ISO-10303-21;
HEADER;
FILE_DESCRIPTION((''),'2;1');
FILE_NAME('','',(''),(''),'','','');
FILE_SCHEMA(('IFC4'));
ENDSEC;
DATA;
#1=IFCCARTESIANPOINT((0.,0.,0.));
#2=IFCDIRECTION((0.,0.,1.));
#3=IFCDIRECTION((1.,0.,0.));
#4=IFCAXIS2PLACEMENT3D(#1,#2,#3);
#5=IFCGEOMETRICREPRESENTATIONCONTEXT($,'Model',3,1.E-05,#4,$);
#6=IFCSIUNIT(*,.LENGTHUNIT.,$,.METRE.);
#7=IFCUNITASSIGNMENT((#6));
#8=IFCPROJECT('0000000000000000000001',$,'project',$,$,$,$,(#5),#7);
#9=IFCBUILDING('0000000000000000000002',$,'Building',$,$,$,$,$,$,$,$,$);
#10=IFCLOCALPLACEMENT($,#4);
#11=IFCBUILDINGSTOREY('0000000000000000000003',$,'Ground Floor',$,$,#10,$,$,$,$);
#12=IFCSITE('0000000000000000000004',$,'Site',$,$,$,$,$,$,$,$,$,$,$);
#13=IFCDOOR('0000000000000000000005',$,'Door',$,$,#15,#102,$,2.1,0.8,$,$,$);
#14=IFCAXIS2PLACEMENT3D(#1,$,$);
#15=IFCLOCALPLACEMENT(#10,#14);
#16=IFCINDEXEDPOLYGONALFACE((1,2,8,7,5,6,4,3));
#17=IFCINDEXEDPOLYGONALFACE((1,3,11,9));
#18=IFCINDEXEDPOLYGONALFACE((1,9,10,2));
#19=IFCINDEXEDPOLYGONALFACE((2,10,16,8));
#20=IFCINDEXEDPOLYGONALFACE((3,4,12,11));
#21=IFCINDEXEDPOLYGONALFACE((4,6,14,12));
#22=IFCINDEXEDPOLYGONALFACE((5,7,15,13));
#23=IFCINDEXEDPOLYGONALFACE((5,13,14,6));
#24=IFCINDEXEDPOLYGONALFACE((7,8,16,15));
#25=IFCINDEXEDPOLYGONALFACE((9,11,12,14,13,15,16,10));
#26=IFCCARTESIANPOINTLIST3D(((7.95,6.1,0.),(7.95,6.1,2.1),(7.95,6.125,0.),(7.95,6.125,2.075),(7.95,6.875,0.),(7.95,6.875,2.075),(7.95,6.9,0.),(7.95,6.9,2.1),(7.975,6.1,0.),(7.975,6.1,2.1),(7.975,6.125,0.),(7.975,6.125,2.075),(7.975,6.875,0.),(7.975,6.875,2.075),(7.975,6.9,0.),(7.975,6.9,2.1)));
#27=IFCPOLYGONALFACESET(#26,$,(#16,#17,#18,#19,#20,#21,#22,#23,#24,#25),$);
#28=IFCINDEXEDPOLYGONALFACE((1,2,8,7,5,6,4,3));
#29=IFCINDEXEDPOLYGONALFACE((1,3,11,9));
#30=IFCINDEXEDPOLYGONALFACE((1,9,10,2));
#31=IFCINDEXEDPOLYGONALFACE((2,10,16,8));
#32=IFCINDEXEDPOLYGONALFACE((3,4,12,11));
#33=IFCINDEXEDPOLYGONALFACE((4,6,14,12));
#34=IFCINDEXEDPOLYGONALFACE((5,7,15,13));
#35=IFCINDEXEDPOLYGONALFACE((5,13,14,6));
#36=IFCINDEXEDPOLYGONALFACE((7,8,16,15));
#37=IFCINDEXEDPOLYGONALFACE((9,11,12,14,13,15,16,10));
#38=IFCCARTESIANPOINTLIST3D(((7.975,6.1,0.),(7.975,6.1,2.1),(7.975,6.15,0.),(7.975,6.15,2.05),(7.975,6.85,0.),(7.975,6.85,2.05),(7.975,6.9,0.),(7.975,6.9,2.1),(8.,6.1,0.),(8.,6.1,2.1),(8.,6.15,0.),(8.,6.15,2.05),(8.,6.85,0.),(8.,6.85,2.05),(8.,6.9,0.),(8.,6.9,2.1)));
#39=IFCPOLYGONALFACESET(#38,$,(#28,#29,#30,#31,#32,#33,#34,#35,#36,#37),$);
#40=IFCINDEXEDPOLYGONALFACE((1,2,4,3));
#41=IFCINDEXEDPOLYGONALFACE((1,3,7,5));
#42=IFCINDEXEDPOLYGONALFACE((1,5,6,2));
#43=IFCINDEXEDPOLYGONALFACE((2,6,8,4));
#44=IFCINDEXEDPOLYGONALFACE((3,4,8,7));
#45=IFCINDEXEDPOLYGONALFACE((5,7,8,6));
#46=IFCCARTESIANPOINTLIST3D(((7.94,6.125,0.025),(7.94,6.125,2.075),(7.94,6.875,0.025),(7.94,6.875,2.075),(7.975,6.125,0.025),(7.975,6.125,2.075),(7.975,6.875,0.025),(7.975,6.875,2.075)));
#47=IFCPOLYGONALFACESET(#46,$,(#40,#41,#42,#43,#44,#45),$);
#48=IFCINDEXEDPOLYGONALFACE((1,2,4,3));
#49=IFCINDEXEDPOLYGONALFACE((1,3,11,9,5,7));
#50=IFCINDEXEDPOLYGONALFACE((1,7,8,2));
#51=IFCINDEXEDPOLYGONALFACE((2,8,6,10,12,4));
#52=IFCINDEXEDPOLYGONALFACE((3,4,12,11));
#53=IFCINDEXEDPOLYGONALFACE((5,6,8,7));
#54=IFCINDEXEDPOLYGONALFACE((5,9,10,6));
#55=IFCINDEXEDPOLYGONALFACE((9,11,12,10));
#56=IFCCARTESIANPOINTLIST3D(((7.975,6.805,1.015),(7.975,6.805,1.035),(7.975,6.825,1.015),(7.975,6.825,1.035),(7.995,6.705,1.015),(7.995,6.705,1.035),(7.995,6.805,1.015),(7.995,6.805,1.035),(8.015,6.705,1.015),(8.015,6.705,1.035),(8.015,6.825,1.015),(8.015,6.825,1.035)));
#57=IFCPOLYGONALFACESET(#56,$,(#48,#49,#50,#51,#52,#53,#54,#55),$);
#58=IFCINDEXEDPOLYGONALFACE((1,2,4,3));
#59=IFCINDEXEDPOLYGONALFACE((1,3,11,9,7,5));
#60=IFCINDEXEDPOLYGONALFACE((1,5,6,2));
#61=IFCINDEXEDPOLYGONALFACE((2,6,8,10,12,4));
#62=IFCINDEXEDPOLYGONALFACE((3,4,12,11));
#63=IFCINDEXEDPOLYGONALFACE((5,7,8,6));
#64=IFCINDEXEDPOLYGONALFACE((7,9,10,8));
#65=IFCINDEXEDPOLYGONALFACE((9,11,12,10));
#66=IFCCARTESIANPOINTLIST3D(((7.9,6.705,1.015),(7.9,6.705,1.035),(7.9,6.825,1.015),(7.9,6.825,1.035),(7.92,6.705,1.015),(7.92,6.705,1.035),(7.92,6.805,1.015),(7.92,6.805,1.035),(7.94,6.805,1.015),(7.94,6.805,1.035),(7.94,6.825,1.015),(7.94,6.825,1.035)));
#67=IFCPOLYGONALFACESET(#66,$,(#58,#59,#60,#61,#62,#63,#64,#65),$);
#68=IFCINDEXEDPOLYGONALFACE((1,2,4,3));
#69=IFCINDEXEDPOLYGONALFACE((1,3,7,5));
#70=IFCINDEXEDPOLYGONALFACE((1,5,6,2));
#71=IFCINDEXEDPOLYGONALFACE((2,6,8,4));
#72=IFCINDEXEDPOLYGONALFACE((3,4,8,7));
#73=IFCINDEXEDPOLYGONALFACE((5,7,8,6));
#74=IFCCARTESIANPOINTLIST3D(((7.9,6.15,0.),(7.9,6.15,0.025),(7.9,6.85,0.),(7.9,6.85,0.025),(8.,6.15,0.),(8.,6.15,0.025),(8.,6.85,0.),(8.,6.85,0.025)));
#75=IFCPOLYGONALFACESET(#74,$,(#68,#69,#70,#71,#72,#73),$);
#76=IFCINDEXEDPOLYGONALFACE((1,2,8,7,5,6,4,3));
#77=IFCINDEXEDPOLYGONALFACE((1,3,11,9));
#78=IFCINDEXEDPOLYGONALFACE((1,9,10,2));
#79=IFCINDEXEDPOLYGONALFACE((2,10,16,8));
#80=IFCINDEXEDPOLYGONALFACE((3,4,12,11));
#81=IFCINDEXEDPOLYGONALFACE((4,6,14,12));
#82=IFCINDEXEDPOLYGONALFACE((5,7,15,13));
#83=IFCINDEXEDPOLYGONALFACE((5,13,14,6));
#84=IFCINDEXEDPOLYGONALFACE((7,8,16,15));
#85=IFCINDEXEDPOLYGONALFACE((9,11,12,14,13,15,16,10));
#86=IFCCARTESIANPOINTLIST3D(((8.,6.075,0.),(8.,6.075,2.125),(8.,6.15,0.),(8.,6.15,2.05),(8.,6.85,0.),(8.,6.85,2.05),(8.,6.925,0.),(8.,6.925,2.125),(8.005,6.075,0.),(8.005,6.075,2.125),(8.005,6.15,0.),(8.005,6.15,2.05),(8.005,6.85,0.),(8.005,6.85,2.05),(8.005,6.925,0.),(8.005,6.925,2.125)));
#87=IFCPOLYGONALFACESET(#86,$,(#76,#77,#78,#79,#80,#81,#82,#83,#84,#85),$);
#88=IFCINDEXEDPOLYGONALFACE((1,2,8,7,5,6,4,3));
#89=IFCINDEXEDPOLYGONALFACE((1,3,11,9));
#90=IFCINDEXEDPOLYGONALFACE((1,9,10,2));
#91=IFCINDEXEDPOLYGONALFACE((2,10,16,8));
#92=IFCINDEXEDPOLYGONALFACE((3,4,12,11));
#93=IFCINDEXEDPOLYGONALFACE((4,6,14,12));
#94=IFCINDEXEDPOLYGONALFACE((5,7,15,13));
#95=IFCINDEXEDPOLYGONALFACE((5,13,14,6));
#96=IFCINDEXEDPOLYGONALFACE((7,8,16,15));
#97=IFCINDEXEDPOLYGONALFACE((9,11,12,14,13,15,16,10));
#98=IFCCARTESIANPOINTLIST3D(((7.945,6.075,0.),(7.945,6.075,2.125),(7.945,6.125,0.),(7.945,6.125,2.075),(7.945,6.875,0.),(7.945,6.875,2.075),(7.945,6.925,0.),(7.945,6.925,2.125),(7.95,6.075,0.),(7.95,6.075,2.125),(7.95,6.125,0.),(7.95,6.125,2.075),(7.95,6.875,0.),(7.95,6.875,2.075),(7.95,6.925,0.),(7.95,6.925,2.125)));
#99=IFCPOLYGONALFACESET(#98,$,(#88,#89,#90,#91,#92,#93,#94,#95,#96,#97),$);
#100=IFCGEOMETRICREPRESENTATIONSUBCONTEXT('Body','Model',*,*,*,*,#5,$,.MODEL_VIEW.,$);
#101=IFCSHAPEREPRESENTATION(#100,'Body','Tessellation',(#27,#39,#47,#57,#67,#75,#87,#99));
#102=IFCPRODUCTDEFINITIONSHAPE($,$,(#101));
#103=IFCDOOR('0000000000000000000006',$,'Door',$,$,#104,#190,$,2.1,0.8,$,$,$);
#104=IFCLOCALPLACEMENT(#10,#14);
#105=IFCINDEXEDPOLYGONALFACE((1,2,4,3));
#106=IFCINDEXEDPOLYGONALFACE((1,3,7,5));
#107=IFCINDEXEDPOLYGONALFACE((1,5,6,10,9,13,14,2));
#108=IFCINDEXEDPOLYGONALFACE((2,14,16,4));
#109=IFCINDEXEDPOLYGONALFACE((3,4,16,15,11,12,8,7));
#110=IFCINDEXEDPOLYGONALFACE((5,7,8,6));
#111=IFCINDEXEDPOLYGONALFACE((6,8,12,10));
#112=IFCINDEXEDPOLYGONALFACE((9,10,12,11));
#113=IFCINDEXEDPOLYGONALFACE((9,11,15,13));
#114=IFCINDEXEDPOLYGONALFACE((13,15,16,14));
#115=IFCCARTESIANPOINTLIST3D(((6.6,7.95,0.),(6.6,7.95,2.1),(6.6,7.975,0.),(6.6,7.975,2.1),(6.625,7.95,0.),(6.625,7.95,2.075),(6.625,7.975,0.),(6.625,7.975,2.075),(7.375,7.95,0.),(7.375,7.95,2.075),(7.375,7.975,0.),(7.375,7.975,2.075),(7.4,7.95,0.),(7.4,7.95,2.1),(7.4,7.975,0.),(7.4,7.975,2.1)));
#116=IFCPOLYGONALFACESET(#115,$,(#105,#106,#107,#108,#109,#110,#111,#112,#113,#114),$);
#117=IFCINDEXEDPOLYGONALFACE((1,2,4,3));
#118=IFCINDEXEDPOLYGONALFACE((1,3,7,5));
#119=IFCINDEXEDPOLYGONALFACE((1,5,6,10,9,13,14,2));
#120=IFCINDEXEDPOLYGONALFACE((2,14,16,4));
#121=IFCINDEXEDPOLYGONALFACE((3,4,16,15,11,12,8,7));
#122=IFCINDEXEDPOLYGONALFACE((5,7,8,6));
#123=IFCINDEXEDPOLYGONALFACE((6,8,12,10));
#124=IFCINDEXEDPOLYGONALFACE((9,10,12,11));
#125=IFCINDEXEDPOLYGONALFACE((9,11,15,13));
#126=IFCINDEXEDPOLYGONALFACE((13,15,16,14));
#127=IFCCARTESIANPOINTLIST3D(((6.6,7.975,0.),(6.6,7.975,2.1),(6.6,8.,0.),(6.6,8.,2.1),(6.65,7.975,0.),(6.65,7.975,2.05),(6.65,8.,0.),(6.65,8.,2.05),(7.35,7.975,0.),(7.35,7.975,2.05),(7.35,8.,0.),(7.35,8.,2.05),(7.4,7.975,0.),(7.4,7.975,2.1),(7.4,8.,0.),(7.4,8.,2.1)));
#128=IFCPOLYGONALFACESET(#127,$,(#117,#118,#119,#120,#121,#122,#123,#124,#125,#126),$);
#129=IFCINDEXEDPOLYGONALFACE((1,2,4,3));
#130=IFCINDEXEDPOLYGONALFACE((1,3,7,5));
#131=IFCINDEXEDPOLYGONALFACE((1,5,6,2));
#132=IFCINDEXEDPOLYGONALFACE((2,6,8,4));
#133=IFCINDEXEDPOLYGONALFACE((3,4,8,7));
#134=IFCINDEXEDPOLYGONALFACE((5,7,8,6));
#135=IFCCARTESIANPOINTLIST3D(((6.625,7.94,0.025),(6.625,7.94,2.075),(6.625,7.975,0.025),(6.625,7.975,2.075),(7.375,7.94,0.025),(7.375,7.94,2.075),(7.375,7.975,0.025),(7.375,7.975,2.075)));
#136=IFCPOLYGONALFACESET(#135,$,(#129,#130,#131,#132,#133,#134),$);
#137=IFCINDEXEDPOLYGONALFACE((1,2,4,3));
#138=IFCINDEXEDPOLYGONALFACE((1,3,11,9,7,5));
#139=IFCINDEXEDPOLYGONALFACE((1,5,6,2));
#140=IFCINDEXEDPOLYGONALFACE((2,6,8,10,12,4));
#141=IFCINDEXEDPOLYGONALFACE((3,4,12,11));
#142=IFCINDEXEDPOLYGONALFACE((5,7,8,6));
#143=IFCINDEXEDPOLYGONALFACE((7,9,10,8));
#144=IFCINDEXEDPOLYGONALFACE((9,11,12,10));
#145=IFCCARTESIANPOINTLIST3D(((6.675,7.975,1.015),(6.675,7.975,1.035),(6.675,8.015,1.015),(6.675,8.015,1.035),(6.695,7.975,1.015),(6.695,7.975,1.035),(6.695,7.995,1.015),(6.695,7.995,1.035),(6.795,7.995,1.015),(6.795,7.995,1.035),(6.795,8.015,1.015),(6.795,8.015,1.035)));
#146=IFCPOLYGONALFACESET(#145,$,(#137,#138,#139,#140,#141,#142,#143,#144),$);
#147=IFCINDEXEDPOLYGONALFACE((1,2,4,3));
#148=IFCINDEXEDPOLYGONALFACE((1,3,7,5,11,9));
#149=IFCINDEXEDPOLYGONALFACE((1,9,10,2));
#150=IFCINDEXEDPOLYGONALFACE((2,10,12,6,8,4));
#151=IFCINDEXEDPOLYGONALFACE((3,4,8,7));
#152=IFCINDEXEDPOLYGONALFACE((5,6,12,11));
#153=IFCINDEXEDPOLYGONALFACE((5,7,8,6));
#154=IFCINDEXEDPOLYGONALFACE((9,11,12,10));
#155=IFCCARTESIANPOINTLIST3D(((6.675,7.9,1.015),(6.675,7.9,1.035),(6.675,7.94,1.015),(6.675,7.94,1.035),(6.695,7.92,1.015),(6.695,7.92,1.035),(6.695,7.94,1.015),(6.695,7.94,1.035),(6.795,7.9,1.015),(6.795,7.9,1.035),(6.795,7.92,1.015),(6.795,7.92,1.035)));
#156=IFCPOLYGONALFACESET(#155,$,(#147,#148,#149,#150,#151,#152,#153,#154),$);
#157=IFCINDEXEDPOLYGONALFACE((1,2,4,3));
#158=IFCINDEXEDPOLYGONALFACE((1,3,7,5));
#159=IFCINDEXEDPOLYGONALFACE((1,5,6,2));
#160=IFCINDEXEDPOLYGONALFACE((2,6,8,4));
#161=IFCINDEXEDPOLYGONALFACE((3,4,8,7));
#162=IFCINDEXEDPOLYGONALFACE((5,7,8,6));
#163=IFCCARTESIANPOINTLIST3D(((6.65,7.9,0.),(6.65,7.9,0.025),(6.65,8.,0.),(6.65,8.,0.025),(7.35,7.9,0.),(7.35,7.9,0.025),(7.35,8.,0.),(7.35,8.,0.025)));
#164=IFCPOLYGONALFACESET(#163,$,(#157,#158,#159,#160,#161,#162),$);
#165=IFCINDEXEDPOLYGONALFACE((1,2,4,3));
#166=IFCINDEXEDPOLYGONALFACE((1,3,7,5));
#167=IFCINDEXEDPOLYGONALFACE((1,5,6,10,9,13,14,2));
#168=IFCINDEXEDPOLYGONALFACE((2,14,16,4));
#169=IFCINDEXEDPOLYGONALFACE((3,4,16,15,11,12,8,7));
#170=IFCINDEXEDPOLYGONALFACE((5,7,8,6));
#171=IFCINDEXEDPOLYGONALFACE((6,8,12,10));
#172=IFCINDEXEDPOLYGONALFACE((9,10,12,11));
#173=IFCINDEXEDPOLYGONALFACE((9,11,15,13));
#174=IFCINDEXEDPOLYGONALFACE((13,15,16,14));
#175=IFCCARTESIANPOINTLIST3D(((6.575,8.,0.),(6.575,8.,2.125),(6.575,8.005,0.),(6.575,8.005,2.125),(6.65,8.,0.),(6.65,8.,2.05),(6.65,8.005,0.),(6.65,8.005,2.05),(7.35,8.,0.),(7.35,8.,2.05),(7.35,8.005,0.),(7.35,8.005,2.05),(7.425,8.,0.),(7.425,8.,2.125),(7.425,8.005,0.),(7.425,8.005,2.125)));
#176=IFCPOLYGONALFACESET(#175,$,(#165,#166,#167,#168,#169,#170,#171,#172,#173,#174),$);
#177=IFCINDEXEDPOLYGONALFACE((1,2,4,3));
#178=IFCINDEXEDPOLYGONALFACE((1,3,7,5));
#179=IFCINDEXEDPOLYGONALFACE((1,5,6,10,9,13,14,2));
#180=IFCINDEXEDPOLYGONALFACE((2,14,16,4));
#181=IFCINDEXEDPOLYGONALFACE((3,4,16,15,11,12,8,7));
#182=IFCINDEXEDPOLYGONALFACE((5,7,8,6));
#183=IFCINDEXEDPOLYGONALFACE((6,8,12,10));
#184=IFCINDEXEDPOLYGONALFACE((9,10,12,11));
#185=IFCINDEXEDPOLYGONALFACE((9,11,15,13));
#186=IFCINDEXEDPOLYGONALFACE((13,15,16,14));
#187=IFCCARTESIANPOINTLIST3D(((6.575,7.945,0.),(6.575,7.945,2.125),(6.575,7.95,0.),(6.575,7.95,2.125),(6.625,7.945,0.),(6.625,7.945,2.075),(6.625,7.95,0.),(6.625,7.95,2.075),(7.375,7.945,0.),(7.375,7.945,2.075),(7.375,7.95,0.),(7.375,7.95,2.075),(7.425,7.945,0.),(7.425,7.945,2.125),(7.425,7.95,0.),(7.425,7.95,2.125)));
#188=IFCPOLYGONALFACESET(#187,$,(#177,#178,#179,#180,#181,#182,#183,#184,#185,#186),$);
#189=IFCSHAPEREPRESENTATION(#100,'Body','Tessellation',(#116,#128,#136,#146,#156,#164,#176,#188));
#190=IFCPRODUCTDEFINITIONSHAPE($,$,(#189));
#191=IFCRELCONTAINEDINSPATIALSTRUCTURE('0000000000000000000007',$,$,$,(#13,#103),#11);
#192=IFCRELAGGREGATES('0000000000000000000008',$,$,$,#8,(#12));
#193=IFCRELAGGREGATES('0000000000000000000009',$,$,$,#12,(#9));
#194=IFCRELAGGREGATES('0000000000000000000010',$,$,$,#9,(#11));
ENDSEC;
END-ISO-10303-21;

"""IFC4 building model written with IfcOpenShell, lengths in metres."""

from ifc_helpers import new_model, si_unit, frame, origin_with_axes, place, context, subcontext, project, spatial, line, indexed_curve, outline, extrude, element, save


model = new_model("IFC4")

# Units and contexts
model_context = context("Model", 3, precision=1e-05, world=origin_with_axes())
body_context = subcontext(model_context, "Body", "Model", "MODEL_VIEW")
ifc_project = project(units=[si_unit("LENGTHUNIT", "METRE")], contexts=[model_context])

# Site, building, storey
site = spatial("IfcSite", under=ifc_project, Name="Site")
building = spatial("IfcBuilding", under=site, Name="Building")
storey_placement = place(None, origin_with_axes())
storey = spatial("IfcBuildingStorey", under=building, at=storey_placement, Name="Ground Floor")

# Doors
door_1_placement = place(storey_placement, frame((8.0, 6.1, 0.0), z_axis=(0.0, 0.0, 1.0), x_axis=(0.0, 1.0, 0.0)))
element("IfcDoor", 1, at=door_1_placement, inside=storey, Name="Door", OverallHeight=2.1, OverallWidth=0.8, context=body_context, shape_type="SweptSolid", body=[
    extrude(outline(indexed_curve([(0.0, 0.0), (0.0, 2.1), (0.8, 2.1), (0.8, 0.0), (0.775, 0.0), (0.775, 2.075), (0.025, 2.075), (0.025, 0.0)], segments=[line(1, 2, 3, 4, 5, 6, 7, 8, 1)])), frame((0.0, 0.025, 0.0), z_axis=(0.0, -1.0, 0.0), x_axis=(1.0, 0.0, 0.0)), (0.0, 0.0, -1.0), 0.025),
    extrude(outline(indexed_curve([(0.0, 0.0), (0.0, 2.1), (0.8, 2.1), (0.8, 0.0), (0.75, 0.0), (0.75, 2.05), (0.05, 2.05), (0.05, 0.0)], segments=[line(1, 2, 3, 4, 5, 6, 7, 8, 1)])), frame((0.0, 0.0, 0.0), z_axis=(0.0, -1.0, 0.0), x_axis=(1.0, 0.0, 0.0)), (0.0, 0.0, -1.0), 0.025),
    extrude(outline(indexed_curve([(0.0, 0.0), (0.75, 0.0), (0.75, 0.035), (0.0, 0.035)], segments=[line(1, 2, 3, 4, 1)])), frame((0.025, 0.025, 0.025), z_axis=(0.0, 0.0, 1.0), x_axis=(1.0, 0.0, 0.0)), (0.0, 0.0, 1.0), 2.05),
    extrude(outline(indexed_curve([(0.0, 0.0), (0.0, -0.04), (-0.12, -0.04), (-0.12, -0.02), (-0.02, -0.02), (-0.02, 0.0)], segments=[line(1, 2, 3, 4, 5, 6, 1)])), frame((0.725, 0.025, 1.015), z_axis=(0.0, 0.0, 1.0), x_axis=(1.0, 0.0, 0.0)), (0.0, 0.0, 1.0), 0.02),
    extrude(outline(indexed_curve([(0.0, 0.0), (0.0, 0.04), (-0.12, 0.04), (-0.12, 0.02), (-0.02, 0.02), (-0.02, 0.0)], segments=[line(1, 2, 3, 4, 5, 6, 1)])), frame((0.725, 0.06, 1.015), z_axis=(0.0, 0.0, 1.0), x_axis=(1.0, 0.0, 0.0)), (0.0, 0.0, 1.0), 0.02),
    extrude(outline(indexed_curve([(0.0, 0.0), (0.7, 0.0), (0.7, 0.1), (0.0, 0.1)], segments=[line(1, 2, 3, 4, 1)])), frame((0.05, 0.0, 0.0), z_axis=(0.0, 0.0, 1.0), x_axis=(1.0, 0.0, 0.0)), (0.0, 0.0, 1.0), 0.025),
    extrude(outline(indexed_curve([(0.0, 0.0), (0.0, 2.125), (0.85, 2.125), (0.85, 0.0), (0.775, 0.0), (0.775, 2.05), (0.075, 2.05), (0.075, 0.0)], segments=[line(1, 2, 3, 4, 5, 6, 7, 8, 1)])), frame((-0.025, -0.005, 0.0), z_axis=(0.0, -1.0, 0.0), x_axis=(1.0, 0.0, 0.0)), (0.0, 0.0, -1.0), 0.005),
    extrude(outline(indexed_curve([(0.0, 0.0), (0.0, 2.125), (0.85, 2.125), (0.85, 0.0), (0.8, 0.0), (0.8, 2.075), (0.05, 2.075), (0.05, 0.0)], segments=[line(1, 2, 3, 4, 5, 6, 7, 8, 1)])), frame((-0.025, 0.05, 0.0), z_axis=(0.0, -1.0, 0.0), x_axis=(1.0, 0.0, 0.0)), (0.0, 0.0, -1.0), 0.005),
])
door_2_placement = place(storey_placement, frame((7.4, 8.0, 0.0), z_axis=(0.0, 0.0, 1.0), x_axis=(-1.0, 0.0, 0.0)))
element("IfcDoor", 2, at=door_2_placement, inside=storey, Name="Door", OverallHeight=2.1, OverallWidth=0.8, context=body_context, shape_type="SweptSolid", body=[
    extrude(outline(indexed_curve([(0.0, 0.0), (0.0, 2.1), (0.8, 2.1), (0.8, 0.0), (0.775, 0.0), (0.775, 2.075), (0.025, 2.075), (0.025, 0.0)], segments=[line(1, 2, 3, 4, 5, 6, 7, 8, 1)])), frame((0.0, 0.025, 0.0), z_axis=(0.0, -1.0, 0.0), x_axis=(1.0, 0.0, 0.0)), (0.0, 0.0, -1.0), 0.025),
    extrude(outline(indexed_curve([(0.0, 0.0), (0.0, 2.1), (0.8, 2.1), (0.8, 0.0), (0.75, 0.0), (0.75, 2.05), (0.05, 2.05), (0.05, 0.0)], segments=[line(1, 2, 3, 4, 5, 6, 7, 8, 1)])), frame((0.0, 0.0, 0.0), z_axis=(0.0, -1.0, 0.0), x_axis=(1.0, 0.0, 0.0)), (0.0, 0.0, -1.0), 0.025),
    extrude(outline(indexed_curve([(0.0, 0.0), (0.75, 0.0), (0.75, 0.035), (0.0, 0.035)], segments=[line(1, 2, 3, 4, 1)])), frame((0.025, 0.025, 0.025), z_axis=(0.0, 0.0, 1.0), x_axis=(1.0, 0.0, 0.0)), (0.0, 0.0, 1.0), 2.05),
    extrude(outline(indexed_curve([(0.0, 0.0), (0.0, -0.04), (-0.12, -0.04), (-0.12, -0.02), (-0.02, -0.02), (-0.02, 0.0)], segments=[line(1, 2, 3, 4, 5, 6, 1)])), frame((0.725, 0.025, 1.015), z_axis=(0.0, 0.0, 1.0), x_axis=(1.0, 0.0, 0.0)), (0.0, 0.0, 1.0), 0.02),
    extrude(outline(indexed_curve([(0.0, 0.0), (0.0, 0.04), (-0.12, 0.04), (-0.12, 0.02), (-0.02, 0.02), (-0.02, 0.0)], segments=[line(1, 2, 3, 4, 5, 6, 1)])), frame((0.725, 0.06, 1.015), z_axis=(0.0, 0.0, 1.0), x_axis=(1.0, 0.0, 0.0)), (0.0, 0.0, 1.0), 0.02),
    extrude(outline(indexed_curve([(0.0, 0.0), (0.7, 0.0), (0.7, 0.1), (0.0, 0.1)], segments=[line(1, 2, 3, 4, 1)])), frame((0.05, 0.0, 0.0), z_axis=(0.0, 0.0, 1.0), x_axis=(1.0, 0.0, 0.0)), (0.0, 0.0, 1.0), 0.025),
    extrude(outline(indexed_curve([(0.0, 0.0), (0.0, 2.125), (0.85, 2.125), (0.85, 0.0), (0.775, 0.0), (0.775, 2.05), (0.075, 2.05), (0.075, 0.0)], segments=[line(1, 2, 3, 4, 5, 6, 7, 8, 1)])), frame((-0.025, -0.005, 0.0), z_axis=(0.0, -1.0, 0.0), x_axis=(1.0, 0.0, 0.0)), (0.0, 0.0, -1.0), 0.005),
    extrude(outline(indexed_curve([(0.0, 0.0), (0.0, 2.125), (0.85, 2.125), (0.85, 0.0), (0.8, 0.0), (0.8, 2.075), (0.05, 2.075), (0.05, 0.0)], segments=[line(1, 2, 3, 4, 5, 6, 7, 8, 1)])), frame((-0.025, 0.05, 0.0), z_axis=(0.0, -1.0, 0.0), x_axis=(1.0, 0.0, 0.0)), (0.0, 0.0, -1.0), 0.005),
])

save(model, "model.ifc")
